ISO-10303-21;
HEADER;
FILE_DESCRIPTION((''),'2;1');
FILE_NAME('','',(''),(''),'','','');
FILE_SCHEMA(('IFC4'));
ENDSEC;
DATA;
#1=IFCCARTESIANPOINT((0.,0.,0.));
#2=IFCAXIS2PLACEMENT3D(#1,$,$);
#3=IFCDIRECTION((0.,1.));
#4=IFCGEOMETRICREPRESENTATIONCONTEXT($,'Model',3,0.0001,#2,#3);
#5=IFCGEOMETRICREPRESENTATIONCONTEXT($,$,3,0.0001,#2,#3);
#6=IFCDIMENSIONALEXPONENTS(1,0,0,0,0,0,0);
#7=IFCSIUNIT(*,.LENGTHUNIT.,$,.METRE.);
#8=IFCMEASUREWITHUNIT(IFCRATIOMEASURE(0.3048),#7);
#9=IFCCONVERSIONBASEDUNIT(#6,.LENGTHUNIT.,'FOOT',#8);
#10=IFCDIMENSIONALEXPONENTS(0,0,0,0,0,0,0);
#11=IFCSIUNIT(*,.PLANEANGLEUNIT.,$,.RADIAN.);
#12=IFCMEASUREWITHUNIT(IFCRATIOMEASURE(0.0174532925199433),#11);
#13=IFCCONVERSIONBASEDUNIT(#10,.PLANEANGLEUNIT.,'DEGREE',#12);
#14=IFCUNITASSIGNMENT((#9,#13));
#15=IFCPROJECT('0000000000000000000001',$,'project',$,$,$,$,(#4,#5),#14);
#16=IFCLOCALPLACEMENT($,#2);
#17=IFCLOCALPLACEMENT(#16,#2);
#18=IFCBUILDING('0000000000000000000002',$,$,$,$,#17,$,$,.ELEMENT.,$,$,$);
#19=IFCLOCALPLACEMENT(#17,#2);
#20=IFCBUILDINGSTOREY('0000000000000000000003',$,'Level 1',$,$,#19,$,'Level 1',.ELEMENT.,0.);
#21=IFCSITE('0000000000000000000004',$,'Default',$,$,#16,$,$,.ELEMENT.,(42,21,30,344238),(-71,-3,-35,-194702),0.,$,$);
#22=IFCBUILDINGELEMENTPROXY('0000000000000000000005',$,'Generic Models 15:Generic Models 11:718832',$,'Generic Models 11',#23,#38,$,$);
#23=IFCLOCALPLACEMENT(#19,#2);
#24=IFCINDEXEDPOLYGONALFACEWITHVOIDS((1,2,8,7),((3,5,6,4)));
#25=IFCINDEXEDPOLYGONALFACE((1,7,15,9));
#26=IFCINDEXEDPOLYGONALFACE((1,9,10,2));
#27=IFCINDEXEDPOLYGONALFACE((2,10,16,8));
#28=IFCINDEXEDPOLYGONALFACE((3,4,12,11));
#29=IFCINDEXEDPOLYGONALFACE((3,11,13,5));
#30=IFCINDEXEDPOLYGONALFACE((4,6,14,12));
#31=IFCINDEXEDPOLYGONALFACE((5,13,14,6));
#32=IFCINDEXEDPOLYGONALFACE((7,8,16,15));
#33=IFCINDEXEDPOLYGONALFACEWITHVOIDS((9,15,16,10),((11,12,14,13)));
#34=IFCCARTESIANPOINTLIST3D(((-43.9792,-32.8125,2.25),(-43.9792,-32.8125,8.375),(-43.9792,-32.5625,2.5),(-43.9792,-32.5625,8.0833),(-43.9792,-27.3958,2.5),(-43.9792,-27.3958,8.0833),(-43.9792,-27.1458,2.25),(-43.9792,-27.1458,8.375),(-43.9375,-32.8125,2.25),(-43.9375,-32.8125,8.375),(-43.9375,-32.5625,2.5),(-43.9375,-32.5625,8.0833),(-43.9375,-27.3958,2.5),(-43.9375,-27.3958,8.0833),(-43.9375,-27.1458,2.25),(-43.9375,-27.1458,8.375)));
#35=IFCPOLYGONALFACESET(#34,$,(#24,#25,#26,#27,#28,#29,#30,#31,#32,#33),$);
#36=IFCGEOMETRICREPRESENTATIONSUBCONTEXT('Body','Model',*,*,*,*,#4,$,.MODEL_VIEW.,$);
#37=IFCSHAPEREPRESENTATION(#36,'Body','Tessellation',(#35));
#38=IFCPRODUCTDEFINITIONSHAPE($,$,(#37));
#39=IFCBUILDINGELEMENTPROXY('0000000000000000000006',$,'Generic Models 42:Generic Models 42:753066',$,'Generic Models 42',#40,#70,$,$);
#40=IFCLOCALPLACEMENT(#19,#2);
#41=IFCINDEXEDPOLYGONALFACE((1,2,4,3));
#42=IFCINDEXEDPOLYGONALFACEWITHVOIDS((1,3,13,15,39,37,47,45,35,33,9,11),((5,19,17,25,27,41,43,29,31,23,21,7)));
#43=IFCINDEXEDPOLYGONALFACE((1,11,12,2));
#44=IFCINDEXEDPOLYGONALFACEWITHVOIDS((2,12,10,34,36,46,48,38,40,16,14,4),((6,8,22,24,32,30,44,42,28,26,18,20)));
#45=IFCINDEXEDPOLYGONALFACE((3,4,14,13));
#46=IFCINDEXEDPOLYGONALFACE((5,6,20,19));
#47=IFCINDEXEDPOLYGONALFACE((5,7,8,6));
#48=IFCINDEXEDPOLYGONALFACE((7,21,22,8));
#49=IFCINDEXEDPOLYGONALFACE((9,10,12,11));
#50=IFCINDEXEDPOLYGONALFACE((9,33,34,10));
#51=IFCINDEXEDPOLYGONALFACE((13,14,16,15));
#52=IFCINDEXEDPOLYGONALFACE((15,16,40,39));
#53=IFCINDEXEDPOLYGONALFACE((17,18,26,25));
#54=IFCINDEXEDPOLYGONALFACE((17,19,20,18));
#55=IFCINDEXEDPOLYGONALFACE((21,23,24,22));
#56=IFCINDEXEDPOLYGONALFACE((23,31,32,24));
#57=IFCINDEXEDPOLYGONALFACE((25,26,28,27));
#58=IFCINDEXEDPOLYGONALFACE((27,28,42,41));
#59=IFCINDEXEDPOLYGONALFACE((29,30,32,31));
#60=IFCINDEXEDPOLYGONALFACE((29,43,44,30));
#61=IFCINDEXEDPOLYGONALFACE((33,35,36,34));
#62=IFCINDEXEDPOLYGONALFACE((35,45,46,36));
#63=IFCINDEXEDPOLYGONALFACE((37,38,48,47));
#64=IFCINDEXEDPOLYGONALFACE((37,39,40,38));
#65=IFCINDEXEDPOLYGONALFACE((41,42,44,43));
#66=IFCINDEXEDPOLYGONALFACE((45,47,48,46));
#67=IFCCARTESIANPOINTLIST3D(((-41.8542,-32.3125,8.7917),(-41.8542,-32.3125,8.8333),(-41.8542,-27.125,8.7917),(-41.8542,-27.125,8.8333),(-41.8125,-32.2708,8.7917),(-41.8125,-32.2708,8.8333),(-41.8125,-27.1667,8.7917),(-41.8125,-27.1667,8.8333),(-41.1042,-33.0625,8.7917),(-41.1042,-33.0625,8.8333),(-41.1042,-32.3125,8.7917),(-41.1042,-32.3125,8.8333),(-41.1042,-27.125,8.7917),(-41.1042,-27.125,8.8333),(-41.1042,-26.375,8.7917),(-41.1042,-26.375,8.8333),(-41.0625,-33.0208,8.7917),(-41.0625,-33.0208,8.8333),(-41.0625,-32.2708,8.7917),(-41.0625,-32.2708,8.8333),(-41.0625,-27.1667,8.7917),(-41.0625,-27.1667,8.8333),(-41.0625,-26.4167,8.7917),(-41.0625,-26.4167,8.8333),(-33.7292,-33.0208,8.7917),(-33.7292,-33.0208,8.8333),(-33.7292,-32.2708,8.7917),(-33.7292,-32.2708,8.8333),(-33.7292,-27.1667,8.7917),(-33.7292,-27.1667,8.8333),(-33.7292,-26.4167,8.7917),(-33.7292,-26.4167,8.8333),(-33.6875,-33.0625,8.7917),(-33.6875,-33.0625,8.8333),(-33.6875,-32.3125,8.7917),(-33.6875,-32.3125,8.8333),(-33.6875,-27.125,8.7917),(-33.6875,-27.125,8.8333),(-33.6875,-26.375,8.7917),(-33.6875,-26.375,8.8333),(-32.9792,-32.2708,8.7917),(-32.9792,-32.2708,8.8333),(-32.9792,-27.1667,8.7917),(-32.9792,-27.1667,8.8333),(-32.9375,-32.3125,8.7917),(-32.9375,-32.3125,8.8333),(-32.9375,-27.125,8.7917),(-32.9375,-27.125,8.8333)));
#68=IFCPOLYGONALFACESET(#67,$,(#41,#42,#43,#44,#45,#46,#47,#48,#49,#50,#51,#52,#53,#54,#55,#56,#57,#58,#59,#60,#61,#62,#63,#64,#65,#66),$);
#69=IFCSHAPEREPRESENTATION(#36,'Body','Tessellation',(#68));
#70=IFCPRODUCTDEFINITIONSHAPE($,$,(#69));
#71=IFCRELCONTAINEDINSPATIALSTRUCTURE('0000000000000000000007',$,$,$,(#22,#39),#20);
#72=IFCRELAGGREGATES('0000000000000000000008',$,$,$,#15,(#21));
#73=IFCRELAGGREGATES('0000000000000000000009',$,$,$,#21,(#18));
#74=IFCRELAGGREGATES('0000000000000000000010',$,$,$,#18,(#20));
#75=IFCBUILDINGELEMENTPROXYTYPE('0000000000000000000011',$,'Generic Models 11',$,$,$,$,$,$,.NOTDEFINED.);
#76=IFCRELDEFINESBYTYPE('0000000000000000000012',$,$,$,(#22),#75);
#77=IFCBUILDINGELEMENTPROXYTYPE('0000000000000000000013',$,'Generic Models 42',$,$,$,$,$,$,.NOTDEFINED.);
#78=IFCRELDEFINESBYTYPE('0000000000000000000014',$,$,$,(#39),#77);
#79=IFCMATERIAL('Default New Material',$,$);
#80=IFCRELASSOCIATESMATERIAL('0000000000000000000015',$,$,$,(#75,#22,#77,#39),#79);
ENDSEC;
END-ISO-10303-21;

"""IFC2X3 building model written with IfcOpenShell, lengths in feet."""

from ifc_helpers import new_model, entity, si_unit, converted_unit, direction, frame, origin, place, context, subcontext, project, spatial, polyline, outline, extrude, source, transform, mapped, material, type_object, type_shapes, element, save


model = new_model("IFC2X3")

# Units and contexts
model_context = context("Model", 3, precision=0.0001, world=origin(), true_north=direction((0.0, 1.0)))
context_of_model = context(None, 3, precision=0.0001, world=origin(), true_north=direction((0.0, 1.0)))
body_context = subcontext(model_context, "Body", "Model", "MODEL_VIEW")
ifc_project = project(units=[converted_unit("LENGTHUNIT", "FOOT", entity("IfcRatioMeasure", 0.3048), si_unit("LENGTHUNIT", "METRE"), dimensions=[1, 0, 0, 0, 0, 0, 0]), converted_unit("PLANEANGLEUNIT", "DEGREE", entity("IfcRatioMeasure", 0.0174532925199433), si_unit("PLANEANGLEUNIT", "RADIAN"), dimensions=[0, 0, 0, 0, 0, 0, 0])], contexts=[model_context, context_of_model])

# Site, building, storey
site_placement = place(None, origin())
site = spatial("IfcSite", under=ifc_project, at=site_placement, Name="Default", CompositionType="ELEMENT", RefLatitude=(42, 21, 30, 344238), RefLongitude=(-71, -3, -35, -194702), RefElevation=0.0)
building_placement = place(site_placement, origin())
building = spatial("IfcBuilding", under=site, at=building_placement, CompositionType="ELEMENT")
storey_placement = place(building_placement, origin())
storey = spatial("IfcBuildingStorey", under=building, at=storey_placement, Name="Level 1", LongName="Level 1", CompositionType="ELEMENT", Elevation=0.0)

# Shared definitions
ifc_material_1 = material(Name="Default New Material")

# Building element proxies
building_element_proxy_type_1 = type_object("IfcBuildingElementProxyType", Name="Generic Models 11", PredefinedType="NOTDEFINED", material=ifc_material_1)
shared_shape_1 = source(origin(), body_context, "Body", "SweptSolid", [
    extrude(outline(polyline([(-2.8333, -3.0625), (2.8333, -3.0625), (2.8333, 3.0625), (-2.8333, 3.0625), (-2.8333, -3.0625)]), holes=[polyline([(-2.5833, -2.7708), (-2.5833, 2.8125), (2.5833, 2.8125), (2.5833, -2.7708), (-2.5833, -2.7708)])]), frame((0.0, 2.8333, 3.0625), z_axis=(1.0, 0.0, 0.0), x_axis=(0.0, -1.0, 0.0)), (0.0, 0.0, 1.0), 0.0417),
])
type_shapes(building_element_proxy_type_1, [shared_shape_1])
proxy_1_placement = place(storey_placement, frame((-43.9792, -32.8125, 2.25)))
element("IfcBuildingElementProxy", 1, at=proxy_1_placement, inside=storey, type_object=building_element_proxy_type_1, material=ifc_material_1, Name="Generic Models 15:Generic Models 11:718832", ObjectType="Generic Models 11", context=body_context, shape_type="MappedRepresentation", body=[
    mapped(shared_shape_1, transform((0.0, 0.0, 0.0), scale=1.0)),
])
building_element_proxy_type_2 = type_object("IfcBuildingElementProxyType", Name="Generic Models 42", PredefinedType="NOTDEFINED", material=ifc_material_1)
shared_shape_2 = source(origin(), body_context, "Body", "SweptSolid", [
    extrude(outline(polyline([(-3.3438, 3.7083), (-3.3437, -3.7083), (-2.5937, -3.7083), (-2.5937, -4.4583), (2.5938, -4.4583), (2.5938, -3.7083), (3.3438, -3.7083), (3.3437, 3.7083), (2.5937, 3.7083), (2.5937, 4.4583), (-2.5938, 4.4583), (-2.5938, 3.7083), (-3.3438, 3.7083)]), holes=[polyline([(-2.5521, -4.4167), (-2.5521, -3.6667), (-3.3021, -3.6667), (-3.3021, 3.6667), (-2.5521, 3.6667), (-2.5521, 4.4167), (2.5521, 4.4167), (2.5521, 3.6667), (3.3021, 3.6667), (3.3021, -3.6667), (2.5521, -3.6667), (2.5521, -4.4167), (-2.5521, -4.4167)])]), frame((4.4583, 3.3438, 0.0), z_axis=(0.0, 0.0, -1.0), x_axis=(0.0, -1.0, 0.0)), (0.0, 0.0, -1.0), 0.0417),
])
type_shapes(building_element_proxy_type_2, [shared_shape_2])
proxy_2_placement = place(storey_placement, frame((-41.8542, -33.0625, 8.7917)))
element("IfcBuildingElementProxy", 2, at=proxy_2_placement, inside=storey, type_object=building_element_proxy_type_2, material=ifc_material_1, Name="Generic Models 42:Generic Models 42:753066", ObjectType="Generic Models 42", context=body_context, shape_type="MappedRepresentation", body=[
    mapped(shared_shape_2, transform((0.0, 0.0, 0.0), scale=1.0)),
])

save(model, "model.ifc")
